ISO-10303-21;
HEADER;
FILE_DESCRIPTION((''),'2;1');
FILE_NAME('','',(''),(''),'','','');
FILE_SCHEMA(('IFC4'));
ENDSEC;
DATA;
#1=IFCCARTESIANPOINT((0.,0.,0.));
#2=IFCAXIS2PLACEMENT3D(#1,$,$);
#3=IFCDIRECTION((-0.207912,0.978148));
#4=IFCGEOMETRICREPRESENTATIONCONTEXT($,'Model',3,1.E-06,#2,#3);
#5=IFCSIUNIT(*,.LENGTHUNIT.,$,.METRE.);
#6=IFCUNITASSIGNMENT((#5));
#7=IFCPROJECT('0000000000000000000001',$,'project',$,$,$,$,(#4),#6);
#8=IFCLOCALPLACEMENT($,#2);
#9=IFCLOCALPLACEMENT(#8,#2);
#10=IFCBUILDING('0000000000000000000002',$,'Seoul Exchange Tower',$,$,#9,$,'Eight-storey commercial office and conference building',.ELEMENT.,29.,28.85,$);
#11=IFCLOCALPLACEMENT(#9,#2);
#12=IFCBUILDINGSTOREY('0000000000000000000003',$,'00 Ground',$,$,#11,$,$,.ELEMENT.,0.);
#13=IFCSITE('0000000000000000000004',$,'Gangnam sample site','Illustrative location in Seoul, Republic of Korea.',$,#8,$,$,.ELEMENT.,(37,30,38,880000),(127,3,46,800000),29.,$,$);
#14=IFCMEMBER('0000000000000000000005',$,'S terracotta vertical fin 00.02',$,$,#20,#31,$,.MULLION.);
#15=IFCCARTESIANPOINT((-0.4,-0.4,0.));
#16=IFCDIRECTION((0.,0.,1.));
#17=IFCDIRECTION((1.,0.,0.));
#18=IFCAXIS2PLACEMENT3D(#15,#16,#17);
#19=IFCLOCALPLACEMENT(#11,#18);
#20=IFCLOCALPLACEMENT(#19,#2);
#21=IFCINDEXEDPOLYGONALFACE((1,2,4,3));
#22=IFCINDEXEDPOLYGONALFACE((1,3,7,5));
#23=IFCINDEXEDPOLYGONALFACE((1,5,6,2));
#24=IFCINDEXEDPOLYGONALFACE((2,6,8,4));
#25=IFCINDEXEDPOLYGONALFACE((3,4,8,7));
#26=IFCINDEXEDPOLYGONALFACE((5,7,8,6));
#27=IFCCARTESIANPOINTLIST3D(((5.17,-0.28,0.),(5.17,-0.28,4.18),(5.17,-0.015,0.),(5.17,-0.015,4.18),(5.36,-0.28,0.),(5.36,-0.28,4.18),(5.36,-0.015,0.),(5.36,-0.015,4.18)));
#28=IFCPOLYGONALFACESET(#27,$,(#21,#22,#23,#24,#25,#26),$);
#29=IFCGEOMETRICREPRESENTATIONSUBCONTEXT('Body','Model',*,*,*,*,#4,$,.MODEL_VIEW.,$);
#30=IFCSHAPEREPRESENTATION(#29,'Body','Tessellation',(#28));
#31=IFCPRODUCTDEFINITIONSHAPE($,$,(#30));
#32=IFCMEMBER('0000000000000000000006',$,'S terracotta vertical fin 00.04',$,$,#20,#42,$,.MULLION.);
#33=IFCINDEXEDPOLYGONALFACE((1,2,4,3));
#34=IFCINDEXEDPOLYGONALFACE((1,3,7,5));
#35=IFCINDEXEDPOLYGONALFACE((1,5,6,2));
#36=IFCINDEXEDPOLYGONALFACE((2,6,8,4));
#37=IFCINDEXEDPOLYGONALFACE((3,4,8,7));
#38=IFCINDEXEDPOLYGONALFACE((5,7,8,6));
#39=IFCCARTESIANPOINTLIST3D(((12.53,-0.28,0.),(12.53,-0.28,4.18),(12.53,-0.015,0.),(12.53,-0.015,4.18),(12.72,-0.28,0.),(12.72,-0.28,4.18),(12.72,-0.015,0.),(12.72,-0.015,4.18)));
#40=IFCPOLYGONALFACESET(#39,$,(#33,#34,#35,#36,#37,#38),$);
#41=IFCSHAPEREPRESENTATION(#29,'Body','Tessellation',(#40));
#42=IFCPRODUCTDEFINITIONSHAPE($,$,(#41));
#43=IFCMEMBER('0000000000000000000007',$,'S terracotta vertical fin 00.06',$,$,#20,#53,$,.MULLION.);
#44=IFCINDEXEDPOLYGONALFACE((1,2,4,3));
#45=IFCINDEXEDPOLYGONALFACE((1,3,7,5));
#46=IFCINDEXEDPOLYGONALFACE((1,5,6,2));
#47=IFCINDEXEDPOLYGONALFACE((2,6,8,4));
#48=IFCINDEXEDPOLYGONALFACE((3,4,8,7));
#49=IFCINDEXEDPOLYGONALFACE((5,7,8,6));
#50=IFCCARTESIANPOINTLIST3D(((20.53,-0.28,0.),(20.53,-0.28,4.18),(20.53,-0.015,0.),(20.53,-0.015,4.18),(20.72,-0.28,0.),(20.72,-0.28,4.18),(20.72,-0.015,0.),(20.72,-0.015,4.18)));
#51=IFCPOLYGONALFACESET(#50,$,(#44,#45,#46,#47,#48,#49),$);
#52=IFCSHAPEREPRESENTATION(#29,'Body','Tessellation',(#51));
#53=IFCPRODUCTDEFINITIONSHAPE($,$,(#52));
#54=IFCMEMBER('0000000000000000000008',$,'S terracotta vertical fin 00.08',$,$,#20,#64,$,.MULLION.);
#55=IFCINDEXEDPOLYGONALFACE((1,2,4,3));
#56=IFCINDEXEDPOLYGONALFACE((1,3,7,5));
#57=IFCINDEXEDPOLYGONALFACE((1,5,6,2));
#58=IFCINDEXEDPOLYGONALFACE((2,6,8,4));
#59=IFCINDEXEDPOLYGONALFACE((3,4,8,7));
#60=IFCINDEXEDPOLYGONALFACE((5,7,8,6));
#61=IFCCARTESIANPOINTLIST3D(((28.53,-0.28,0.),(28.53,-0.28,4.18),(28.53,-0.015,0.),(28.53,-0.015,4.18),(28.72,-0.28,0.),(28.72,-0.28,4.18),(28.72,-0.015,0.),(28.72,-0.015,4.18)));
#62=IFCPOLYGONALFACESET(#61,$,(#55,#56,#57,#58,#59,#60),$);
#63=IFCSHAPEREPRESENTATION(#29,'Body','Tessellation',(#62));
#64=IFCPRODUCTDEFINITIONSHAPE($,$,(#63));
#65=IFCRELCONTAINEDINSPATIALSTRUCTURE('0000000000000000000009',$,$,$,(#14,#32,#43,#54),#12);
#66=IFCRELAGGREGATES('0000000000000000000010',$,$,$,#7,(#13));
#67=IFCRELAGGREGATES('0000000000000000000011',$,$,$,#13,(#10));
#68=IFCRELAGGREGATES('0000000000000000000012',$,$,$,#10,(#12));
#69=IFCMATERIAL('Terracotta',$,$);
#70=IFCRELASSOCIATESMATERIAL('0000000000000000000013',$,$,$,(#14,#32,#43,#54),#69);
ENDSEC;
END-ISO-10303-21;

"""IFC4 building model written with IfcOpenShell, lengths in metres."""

from ifc_helpers import new_model, si_unit, direction, frame, frame_2d, origin, place, context, subcontext, project, spatial, rectangle, extrude, material, element, save


model = new_model("IFC4")

# Units and contexts
model_context = context("Model", 3, precision=1e-06, world=origin(), true_north=direction((-0.207912, 0.978148)))
body_context = subcontext(model_context, "Body", "Model", "MODEL_VIEW")
ifc_project = project(units=[si_unit("LENGTHUNIT", "METRE")], contexts=[model_context])

# Site, building, storey
site_placement = place(None, origin())
site = spatial("IfcSite", under=ifc_project, at=site_placement, Name="Gangnam sample site", Description="Illustrative location in Seoul, Republic of Korea.", CompositionType="ELEMENT", RefLatitude=(37, 30, 38, 880000), RefLongitude=(127, 3, 46, 800000), RefElevation=29.0)
building_placement = place(site_placement, origin())
building = spatial("IfcBuilding", under=site, at=building_placement, Name="Seoul Exchange Tower", LongName="Eight-storey commercial office and conference building", CompositionType="ELEMENT", ElevationOfRefHeight=29.0, ElevationOfTerrain=28.85)
storey_placement = place(building_placement, origin())
storey = spatial("IfcBuildingStorey", under=building, at=storey_placement, Name="00 Ground", CompositionType="ELEMENT", Elevation=0.0)

# Members
ifc_material_1 = material(Name="Terracotta")
wall_placement = place(storey_placement, frame((-0.4, -0.4, 0.0), z_axis=(0.0, 0.0, 1.0), x_axis=(1.0, 0.0, 0.0)))
placement = place(wall_placement, origin())
element("IfcMember", 1, at=placement, inside=storey, material=ifc_material_1, Name="S terracotta vertical fin 00.02", PredefinedType="MULLION", context=body_context, shape_type="SweptSolid", body=[
    extrude(rectangle(XDim=0.19, YDim=0.265, at=frame_2d((0.095, 0.1325))), frame((5.17, -0.28, 0.0)), (0.0, 0.0, 1.0), 4.18),
])
element("IfcMember", 2, at=placement, inside=storey, material=ifc_material_1, Name="S terracotta vertical fin 00.04", PredefinedType="MULLION", context=body_context, shape_type="SweptSolid", body=[
    extrude(rectangle(XDim=0.19, YDim=0.265, at=frame_2d((0.095, 0.1325))), frame((12.53, -0.28, 0.0)), (0.0, 0.0, 1.0), 4.18),
])
element("IfcMember", 3, at=placement, inside=storey, material=ifc_material_1, Name="S terracotta vertical fin 00.06", PredefinedType="MULLION", context=body_context, shape_type="SweptSolid", body=[
    extrude(rectangle(XDim=0.19, YDim=0.265, at=frame_2d((0.095, 0.1325))), frame((20.53, -0.28, 0.0)), (0.0, 0.0, 1.0), 4.18),
])
element("IfcMember", 4, at=placement, inside=storey, material=ifc_material_1, Name="S terracotta vertical fin 00.08", PredefinedType="MULLION", context=body_context, shape_type="SweptSolid", body=[
    extrude(rectangle(XDim=0.19, YDim=0.265, at=frame_2d((0.095, 0.1325))), frame((28.53, -0.28, 0.0)), (0.0, 0.0, 1.0), 4.18),
])

save(model, "model.ifc")
